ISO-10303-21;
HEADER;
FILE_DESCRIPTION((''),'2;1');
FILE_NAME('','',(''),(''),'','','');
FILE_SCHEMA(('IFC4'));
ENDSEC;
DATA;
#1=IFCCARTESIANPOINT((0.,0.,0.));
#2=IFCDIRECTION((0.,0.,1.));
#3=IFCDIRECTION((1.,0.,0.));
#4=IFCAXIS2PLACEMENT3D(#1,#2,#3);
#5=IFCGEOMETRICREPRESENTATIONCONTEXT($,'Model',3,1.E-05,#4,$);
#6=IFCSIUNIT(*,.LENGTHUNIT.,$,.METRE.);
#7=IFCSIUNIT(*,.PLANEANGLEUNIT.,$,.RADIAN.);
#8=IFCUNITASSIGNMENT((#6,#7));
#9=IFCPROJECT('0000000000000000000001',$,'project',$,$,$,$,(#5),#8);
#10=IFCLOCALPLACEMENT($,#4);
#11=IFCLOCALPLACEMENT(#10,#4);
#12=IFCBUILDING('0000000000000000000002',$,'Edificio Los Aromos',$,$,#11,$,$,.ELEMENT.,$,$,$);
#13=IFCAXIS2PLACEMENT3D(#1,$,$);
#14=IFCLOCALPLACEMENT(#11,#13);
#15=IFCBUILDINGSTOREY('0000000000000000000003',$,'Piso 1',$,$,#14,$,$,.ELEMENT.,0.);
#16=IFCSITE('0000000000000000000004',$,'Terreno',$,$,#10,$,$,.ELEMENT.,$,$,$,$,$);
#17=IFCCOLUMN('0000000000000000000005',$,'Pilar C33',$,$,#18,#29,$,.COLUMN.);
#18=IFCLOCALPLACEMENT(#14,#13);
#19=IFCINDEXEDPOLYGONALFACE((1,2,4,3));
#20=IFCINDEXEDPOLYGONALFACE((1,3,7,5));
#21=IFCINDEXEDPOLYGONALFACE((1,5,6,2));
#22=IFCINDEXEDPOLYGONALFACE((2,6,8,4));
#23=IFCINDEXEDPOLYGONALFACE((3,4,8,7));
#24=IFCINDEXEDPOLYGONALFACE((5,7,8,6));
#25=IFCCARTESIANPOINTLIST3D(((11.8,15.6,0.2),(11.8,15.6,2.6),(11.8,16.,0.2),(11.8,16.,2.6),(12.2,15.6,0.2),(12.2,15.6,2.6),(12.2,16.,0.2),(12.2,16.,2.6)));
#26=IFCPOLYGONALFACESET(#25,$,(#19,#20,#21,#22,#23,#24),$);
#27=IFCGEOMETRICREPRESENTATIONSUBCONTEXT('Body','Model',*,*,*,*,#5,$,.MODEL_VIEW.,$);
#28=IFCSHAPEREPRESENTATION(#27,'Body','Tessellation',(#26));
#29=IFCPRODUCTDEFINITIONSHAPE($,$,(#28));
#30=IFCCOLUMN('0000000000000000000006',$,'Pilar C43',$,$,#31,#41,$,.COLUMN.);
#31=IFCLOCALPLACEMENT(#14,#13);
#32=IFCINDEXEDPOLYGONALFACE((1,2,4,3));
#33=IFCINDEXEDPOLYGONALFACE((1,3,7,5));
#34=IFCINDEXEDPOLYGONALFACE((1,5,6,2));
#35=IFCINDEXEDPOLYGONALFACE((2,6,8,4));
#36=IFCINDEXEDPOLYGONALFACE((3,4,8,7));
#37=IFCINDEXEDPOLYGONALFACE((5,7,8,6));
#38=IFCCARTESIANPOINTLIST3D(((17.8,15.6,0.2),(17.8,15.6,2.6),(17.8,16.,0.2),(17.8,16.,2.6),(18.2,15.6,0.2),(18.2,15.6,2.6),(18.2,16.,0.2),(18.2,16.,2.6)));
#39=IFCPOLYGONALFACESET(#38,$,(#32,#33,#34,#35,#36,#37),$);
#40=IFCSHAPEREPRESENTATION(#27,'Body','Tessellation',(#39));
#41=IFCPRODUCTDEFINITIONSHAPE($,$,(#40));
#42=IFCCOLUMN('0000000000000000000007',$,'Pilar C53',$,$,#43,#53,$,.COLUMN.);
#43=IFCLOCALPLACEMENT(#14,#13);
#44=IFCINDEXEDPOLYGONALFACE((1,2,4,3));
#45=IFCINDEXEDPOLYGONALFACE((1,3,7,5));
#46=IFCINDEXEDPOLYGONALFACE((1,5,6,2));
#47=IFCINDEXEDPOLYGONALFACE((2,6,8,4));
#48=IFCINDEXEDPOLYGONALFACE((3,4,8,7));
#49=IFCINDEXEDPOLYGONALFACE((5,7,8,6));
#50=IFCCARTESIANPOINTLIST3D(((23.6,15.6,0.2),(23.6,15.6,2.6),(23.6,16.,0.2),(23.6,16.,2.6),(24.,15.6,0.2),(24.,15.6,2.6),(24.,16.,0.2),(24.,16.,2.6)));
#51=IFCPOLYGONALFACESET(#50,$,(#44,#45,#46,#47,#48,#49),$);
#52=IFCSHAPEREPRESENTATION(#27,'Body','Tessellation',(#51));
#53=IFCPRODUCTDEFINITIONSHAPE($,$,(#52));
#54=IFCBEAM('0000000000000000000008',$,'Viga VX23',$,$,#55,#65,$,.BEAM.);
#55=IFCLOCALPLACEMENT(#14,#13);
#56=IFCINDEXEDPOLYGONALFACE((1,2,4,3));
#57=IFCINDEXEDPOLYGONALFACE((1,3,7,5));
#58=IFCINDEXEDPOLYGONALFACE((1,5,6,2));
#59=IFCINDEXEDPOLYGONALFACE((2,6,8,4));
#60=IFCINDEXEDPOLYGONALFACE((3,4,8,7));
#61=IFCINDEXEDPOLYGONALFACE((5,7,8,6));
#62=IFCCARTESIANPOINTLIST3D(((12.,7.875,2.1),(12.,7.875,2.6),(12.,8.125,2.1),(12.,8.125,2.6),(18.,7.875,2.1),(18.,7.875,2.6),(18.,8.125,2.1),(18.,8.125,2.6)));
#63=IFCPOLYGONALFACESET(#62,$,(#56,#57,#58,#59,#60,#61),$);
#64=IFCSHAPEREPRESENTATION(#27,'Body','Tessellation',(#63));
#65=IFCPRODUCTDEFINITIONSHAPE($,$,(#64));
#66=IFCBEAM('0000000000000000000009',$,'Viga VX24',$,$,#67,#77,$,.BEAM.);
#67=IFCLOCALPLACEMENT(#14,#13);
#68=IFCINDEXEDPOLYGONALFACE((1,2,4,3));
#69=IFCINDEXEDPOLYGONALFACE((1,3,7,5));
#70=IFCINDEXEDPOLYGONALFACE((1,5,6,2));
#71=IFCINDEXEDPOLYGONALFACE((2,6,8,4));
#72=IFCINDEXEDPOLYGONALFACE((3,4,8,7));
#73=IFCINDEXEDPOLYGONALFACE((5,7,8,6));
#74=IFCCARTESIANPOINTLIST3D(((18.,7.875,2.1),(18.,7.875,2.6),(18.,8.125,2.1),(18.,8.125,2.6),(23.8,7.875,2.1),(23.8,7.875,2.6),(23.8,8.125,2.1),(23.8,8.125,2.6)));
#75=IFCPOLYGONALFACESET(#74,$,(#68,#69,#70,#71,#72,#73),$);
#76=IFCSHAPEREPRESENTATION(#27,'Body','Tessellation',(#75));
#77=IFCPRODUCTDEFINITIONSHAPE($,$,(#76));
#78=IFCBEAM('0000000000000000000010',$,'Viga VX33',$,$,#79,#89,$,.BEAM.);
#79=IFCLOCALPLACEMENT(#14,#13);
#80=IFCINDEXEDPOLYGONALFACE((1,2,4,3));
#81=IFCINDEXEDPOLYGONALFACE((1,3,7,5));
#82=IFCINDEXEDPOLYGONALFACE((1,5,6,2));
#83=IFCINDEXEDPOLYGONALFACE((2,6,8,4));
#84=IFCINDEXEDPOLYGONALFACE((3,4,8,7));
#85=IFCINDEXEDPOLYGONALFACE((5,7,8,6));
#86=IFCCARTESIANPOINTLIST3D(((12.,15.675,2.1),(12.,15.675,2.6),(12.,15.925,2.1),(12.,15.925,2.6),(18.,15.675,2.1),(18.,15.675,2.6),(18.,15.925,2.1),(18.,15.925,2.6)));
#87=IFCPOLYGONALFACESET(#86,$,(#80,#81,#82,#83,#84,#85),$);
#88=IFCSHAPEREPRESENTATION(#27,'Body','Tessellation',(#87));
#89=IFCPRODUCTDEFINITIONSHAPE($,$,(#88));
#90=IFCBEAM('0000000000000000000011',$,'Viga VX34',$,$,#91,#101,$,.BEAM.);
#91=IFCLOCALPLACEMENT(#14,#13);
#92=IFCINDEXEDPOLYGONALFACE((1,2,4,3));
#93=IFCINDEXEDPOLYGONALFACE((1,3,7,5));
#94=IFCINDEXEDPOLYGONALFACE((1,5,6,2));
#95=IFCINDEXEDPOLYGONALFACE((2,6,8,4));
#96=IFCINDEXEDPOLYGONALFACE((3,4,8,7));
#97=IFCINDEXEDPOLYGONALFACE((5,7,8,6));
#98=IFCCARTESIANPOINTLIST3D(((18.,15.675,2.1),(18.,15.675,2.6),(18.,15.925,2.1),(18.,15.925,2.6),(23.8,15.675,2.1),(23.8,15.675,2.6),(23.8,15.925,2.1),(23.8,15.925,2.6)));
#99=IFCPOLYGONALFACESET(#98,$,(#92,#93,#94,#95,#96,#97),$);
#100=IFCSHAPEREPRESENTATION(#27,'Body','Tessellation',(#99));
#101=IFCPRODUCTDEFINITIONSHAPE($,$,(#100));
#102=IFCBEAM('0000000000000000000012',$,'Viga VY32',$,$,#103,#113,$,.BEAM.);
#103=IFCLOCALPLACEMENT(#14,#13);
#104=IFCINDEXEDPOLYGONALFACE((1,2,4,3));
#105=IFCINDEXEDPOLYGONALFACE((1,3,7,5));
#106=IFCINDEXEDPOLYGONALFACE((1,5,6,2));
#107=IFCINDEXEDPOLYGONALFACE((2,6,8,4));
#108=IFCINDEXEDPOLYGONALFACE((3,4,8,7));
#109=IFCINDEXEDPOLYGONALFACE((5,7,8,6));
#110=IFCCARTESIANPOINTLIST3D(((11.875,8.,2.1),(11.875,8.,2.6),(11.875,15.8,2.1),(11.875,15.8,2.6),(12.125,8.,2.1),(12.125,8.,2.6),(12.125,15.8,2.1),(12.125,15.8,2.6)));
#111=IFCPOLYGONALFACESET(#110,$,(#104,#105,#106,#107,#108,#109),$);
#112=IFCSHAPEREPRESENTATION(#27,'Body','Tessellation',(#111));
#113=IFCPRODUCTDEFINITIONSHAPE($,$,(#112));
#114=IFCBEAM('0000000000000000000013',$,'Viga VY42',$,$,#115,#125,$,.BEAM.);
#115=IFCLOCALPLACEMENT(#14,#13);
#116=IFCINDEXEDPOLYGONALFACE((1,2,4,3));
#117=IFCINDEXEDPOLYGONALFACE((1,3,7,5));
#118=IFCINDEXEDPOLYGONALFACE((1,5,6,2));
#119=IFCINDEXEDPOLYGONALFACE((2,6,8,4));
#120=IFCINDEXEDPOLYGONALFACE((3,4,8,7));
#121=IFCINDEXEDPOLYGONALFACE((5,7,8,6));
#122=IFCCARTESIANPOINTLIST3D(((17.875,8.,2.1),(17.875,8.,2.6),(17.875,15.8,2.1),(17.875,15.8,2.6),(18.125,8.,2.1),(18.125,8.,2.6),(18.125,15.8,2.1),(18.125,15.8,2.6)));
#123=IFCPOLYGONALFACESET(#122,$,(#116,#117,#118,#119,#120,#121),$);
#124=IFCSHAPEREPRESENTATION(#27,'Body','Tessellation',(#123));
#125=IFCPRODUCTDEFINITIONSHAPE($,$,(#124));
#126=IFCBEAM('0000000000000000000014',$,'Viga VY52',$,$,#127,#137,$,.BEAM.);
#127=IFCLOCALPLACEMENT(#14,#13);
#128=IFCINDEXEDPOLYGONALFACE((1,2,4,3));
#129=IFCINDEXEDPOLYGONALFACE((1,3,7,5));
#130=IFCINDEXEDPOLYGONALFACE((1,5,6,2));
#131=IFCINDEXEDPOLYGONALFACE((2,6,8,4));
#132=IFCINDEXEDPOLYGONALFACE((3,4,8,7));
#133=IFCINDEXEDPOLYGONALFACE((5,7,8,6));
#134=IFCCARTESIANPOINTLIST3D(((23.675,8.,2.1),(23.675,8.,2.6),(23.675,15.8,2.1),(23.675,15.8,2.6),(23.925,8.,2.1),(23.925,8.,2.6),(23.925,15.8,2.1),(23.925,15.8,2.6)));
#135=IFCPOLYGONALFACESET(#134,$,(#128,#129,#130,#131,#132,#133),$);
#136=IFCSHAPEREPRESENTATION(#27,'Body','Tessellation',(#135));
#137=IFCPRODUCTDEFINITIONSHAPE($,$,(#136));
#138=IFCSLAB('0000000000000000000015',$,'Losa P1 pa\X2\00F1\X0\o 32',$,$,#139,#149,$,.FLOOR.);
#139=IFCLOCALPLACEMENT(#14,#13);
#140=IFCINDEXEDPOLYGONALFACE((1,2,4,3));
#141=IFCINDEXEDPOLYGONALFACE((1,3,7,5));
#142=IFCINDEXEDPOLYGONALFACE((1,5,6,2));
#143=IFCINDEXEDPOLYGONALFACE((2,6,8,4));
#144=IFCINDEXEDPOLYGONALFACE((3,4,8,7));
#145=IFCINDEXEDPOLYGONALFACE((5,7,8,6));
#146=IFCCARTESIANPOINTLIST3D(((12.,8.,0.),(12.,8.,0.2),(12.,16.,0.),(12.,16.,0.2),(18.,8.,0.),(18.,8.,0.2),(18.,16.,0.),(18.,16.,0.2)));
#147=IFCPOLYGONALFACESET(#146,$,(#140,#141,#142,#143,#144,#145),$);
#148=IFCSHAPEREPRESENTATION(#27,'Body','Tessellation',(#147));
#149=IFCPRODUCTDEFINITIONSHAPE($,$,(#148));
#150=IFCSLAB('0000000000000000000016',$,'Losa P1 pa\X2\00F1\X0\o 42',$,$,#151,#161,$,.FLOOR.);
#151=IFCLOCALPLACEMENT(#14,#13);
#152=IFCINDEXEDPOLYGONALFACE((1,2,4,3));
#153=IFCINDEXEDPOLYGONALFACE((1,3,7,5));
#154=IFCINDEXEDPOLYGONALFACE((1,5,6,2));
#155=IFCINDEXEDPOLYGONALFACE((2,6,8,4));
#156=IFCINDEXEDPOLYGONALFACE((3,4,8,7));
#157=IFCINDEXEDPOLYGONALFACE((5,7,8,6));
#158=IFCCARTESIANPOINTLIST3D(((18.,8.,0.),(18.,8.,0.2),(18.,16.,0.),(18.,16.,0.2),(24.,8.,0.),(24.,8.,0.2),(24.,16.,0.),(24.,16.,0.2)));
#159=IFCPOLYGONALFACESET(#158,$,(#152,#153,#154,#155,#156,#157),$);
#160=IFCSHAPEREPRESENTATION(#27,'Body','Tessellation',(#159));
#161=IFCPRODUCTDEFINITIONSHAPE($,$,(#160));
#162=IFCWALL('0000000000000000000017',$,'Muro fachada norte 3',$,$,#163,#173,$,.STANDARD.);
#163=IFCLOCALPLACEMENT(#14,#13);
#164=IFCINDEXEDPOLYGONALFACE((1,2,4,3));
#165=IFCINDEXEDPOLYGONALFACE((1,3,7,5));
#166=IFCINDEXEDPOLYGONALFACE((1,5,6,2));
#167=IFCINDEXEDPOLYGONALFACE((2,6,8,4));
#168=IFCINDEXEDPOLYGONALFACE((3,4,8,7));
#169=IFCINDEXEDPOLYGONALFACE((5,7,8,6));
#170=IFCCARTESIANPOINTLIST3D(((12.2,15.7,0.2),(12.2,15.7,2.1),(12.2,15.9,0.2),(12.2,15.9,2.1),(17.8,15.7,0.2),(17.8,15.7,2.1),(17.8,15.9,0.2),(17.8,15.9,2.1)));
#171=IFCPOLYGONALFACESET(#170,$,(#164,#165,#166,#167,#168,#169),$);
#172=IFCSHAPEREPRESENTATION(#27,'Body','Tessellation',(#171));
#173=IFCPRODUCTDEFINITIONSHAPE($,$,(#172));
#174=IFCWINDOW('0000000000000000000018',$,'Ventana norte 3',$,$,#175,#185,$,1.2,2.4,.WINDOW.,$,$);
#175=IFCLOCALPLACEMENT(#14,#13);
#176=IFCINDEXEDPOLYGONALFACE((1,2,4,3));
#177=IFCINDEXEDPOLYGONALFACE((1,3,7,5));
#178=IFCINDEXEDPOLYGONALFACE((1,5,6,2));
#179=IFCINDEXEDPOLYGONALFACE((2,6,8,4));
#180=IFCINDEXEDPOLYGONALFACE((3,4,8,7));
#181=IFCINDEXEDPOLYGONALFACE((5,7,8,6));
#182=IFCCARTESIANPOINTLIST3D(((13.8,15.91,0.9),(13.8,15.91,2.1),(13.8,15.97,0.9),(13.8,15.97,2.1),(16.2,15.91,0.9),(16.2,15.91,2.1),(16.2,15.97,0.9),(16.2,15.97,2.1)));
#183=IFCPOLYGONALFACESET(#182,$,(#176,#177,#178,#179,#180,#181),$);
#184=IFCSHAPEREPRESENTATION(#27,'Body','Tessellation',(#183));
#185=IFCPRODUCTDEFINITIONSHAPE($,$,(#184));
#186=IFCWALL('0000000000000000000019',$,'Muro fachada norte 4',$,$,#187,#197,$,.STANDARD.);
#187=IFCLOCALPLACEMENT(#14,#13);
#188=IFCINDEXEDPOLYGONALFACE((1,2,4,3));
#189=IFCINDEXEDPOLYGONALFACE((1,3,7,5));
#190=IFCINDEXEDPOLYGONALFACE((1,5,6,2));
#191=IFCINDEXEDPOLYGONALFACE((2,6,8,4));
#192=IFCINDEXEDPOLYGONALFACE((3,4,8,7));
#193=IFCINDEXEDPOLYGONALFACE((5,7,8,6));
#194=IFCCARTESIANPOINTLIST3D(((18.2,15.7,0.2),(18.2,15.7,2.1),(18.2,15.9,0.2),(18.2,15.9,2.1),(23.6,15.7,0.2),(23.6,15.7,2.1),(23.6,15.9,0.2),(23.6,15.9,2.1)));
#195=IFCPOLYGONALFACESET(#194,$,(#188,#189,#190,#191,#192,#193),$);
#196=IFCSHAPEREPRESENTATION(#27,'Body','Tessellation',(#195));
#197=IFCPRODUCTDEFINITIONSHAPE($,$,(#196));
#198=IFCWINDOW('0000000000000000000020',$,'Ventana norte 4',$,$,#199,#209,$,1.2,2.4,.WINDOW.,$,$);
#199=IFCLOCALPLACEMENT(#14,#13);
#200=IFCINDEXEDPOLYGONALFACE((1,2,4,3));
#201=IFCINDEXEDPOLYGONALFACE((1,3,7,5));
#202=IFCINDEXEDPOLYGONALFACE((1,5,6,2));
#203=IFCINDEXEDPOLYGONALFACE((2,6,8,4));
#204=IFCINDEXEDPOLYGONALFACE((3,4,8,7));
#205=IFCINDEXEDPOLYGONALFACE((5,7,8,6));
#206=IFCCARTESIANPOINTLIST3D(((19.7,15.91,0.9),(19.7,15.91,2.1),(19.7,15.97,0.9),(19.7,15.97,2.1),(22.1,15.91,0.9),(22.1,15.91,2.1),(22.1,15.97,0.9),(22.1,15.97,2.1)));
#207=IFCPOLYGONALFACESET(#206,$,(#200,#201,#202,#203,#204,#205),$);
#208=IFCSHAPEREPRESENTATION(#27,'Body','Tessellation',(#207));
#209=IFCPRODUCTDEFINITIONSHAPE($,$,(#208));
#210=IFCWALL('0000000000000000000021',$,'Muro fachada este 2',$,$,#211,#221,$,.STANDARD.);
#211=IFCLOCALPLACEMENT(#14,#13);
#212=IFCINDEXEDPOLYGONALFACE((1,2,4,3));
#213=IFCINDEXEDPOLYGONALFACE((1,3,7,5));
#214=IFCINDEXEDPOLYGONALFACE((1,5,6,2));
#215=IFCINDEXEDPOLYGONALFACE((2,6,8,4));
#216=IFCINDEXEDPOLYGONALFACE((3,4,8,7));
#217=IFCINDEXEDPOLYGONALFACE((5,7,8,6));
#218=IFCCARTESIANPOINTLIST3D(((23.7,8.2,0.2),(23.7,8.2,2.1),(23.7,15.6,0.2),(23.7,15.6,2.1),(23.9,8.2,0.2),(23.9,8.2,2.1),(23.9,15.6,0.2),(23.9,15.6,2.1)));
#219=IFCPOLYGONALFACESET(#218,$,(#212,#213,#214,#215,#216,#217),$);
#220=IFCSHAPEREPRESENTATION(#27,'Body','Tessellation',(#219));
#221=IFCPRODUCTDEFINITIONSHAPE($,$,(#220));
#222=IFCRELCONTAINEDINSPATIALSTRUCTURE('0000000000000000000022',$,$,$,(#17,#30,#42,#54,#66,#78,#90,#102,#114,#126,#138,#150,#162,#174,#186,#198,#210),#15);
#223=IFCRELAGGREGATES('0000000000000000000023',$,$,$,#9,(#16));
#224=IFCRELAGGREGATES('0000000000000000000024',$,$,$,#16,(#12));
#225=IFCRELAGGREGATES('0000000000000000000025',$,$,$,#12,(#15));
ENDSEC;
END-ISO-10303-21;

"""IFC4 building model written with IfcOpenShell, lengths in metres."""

from ifc_helpers import new_model, si_unit, frame, frame_2d, origin, origin_with_axes, place, context, subcontext, project, spatial, rectangle, extrude, element, save


model = new_model("IFC4")

# Units and contexts
model_context = context("Model", 3, precision=1e-05, world=origin_with_axes())
body_context = subcontext(model_context, "Body", "Model", "MODEL_VIEW")
ifc_project = project(units=[si_unit("LENGTHUNIT", "METRE"), si_unit("PLANEANGLEUNIT", "RADIAN")], contexts=[model_context])

# Site, building, storey
site_placement = place(None, origin_with_axes())
site = spatial("IfcSite", under=ifc_project, at=site_placement, Name="Terreno", CompositionType="ELEMENT")
building_placement = place(site_placement, origin_with_axes())
building = spatial("IfcBuilding", under=site, at=building_placement, Name="Edificio Los Aromos", CompositionType="ELEMENT")
storey_placement = place(building_placement, origin())
storey = spatial("IfcBuildingStorey", under=building, at=storey_placement, Name="Piso 1", CompositionType="ELEMENT", Elevation=0.0)

# Columns
for number, where, name in (
    (1, (11.8, 15.6, 0.2), "Pilar C33"),
    (2, (17.8, 15.6, 0.2), "Pilar C43"),
    (3, (23.6, 15.6, 0.2), "Pilar C53"),
):
    element("IfcColumn", number, at=place(storey_placement, frame(where)), inside=storey, Name=name, PredefinedType="COLUMN", context=body_context, shape_type="SweptSolid", body=[
        extrude(rectangle(XDim=0.4, YDim=0.4, at=frame_2d((0.2, 0.2))), origin_with_axes(), (0.0, 0.0, 1.0), 2.4),
    ])

# Beams
beam_1_placement = place(storey_placement, frame((12.0, 7.875, 2.1)))
element("IfcBeam", 4, at=beam_1_placement, inside=storey, Name="Viga VX23", PredefinedType="BEAM", context=body_context, shape_type="SweptSolid", body=[
    extrude(rectangle(XDim=6.0, YDim=0.25, at=frame_2d((3.0, 0.125))), origin_with_axes(), (0.0, 0.0, 1.0), 0.5),
])
beam_2_placement = place(storey_placement, frame((18.0, 7.875, 2.1)))
element("IfcBeam", 5, at=beam_2_placement, inside=storey, Name="Viga VX24", PredefinedType="BEAM", context=body_context, shape_type="SweptSolid", body=[
    extrude(rectangle(XDim=5.8, YDim=0.25, at=frame_2d((2.9, 0.125))), origin_with_axes(), (0.0, 0.0, 1.0), 0.5),
])
beam_3_placement = place(storey_placement, frame((12.0, 15.675, 2.1)))
element("IfcBeam", 6, at=beam_3_placement, inside=storey, Name="Viga VX33", PredefinedType="BEAM", context=body_context, shape_type="SweptSolid", body=[
    extrude(rectangle(XDim=6.0, YDim=0.25, at=frame_2d((3.0, 0.125))), origin_with_axes(), (0.0, 0.0, 1.0), 0.5),
])
beam_4_placement = place(storey_placement, frame((18.0, 15.675, 2.1)))
element("IfcBeam", 7, at=beam_4_placement, inside=storey, Name="Viga VX34", PredefinedType="BEAM", context=body_context, shape_type="SweptSolid", body=[
    extrude(rectangle(XDim=5.8, YDim=0.25, at=frame_2d((2.9, 0.125))), origin_with_axes(), (0.0, 0.0, 1.0), 0.5),
])
for number, where, name in (
    (8, (11.875, 8.0, 2.1), "Viga VY32"),
    (9, (17.875, 8.0, 2.1), "Viga VY42"),
    (10, (23.675, 8.0, 2.1), "Viga VY52"),
):
    element("IfcBeam", number, at=place(storey_placement, frame(where)), inside=storey, Name=name, PredefinedType="BEAM", context=body_context, shape_type="SweptSolid", body=[
        extrude(rectangle(XDim=0.25, YDim=7.8, at=frame_2d((0.125, 3.9))), origin_with_axes(), (0.0, 0.0, 1.0), 0.5),
    ])

# Slabs
for number, where, name in (
    (11, (12.0, 8.0, 0.0), "Losa P1 paño 32"),
    (12, (18.0, 8.0, 0.0), "Losa P1 paño 42"),
):
    element("IfcSlab", number, at=place(storey_placement, frame(where)), inside=storey, Name=name, PredefinedType="FLOOR", context=body_context, shape_type="SweptSolid", body=[
        extrude(rectangle(XDim=6.0, YDim=8.0, at=frame_2d((3.0, 4.0))), origin_with_axes(), (0.0, 0.0, 1.0), 0.2),
    ])

# Wall
wall_1_placement = place(storey_placement, frame((12.2, 15.7, 0.2)))
element("IfcWall", 13, at=wall_1_placement, inside=storey, Name="Muro fachada norte 3", PredefinedType="STANDARD", context=body_context, shape_type="SweptSolid", body=[
    extrude(rectangle(XDim=5.6, YDim=0.2, at=frame_2d((2.8, 0.1))), origin_with_axes(), (0.0, 0.0, 1.0), 1.9),
])

# Window
window_1_placement = place(storey_placement, frame((13.8, 15.91, 0.9)))
element("IfcWindow", 14, at=window_1_placement, inside=storey, Name="Ventana norte 3", OverallHeight=1.2, OverallWidth=2.4, PredefinedType="WINDOW", context=body_context, shape_type="SweptSolid", body=[
    extrude(rectangle(XDim=2.4, YDim=0.06, at=frame_2d((1.2, 0.03))), origin_with_axes(), (0.0, 0.0, 1.0), 1.2),
])

# Wall
wall_2_placement = place(storey_placement, frame((18.2, 15.7, 0.2)))
element("IfcWall", 15, at=wall_2_placement, inside=storey, Name="Muro fachada norte 4", PredefinedType="STANDARD", context=body_context, shape_type="SweptSolid", body=[
    extrude(rectangle(XDim=5.4, YDim=0.2, at=frame_2d((2.7, 0.1))), origin_with_axes(), (0.0, 0.0, 1.0), 1.9),
])

# Window
window_2_placement = place(storey_placement, frame((19.7, 15.91, 0.9)))
element("IfcWindow", 16, at=window_2_placement, inside=storey, Name="Ventana norte 4", OverallHeight=1.2, OverallWidth=2.4, PredefinedType="WINDOW", context=body_context, shape_type="SweptSolid", body=[
    extrude(rectangle(XDim=2.4, YDim=0.06, at=frame_2d((1.2, 0.03))), origin_with_axes(), (0.0, 0.0, 1.0), 1.2),
])

# Wall
wall_3_placement = place(storey_placement, frame((23.7, 8.2, 0.2)))
element("IfcWall", 17, at=wall_3_placement, inside=storey, Name="Muro fachada este 2", PredefinedType="STANDARD", context=body_context, shape_type="SweptSolid", body=[
    extrude(rectangle(XDim=0.2, YDim=7.4, at=frame_2d((0.1, 3.7))), origin_with_axes(), (0.0, 0.0, 1.0), 1.9),
])

save(model, "model.ifc")
